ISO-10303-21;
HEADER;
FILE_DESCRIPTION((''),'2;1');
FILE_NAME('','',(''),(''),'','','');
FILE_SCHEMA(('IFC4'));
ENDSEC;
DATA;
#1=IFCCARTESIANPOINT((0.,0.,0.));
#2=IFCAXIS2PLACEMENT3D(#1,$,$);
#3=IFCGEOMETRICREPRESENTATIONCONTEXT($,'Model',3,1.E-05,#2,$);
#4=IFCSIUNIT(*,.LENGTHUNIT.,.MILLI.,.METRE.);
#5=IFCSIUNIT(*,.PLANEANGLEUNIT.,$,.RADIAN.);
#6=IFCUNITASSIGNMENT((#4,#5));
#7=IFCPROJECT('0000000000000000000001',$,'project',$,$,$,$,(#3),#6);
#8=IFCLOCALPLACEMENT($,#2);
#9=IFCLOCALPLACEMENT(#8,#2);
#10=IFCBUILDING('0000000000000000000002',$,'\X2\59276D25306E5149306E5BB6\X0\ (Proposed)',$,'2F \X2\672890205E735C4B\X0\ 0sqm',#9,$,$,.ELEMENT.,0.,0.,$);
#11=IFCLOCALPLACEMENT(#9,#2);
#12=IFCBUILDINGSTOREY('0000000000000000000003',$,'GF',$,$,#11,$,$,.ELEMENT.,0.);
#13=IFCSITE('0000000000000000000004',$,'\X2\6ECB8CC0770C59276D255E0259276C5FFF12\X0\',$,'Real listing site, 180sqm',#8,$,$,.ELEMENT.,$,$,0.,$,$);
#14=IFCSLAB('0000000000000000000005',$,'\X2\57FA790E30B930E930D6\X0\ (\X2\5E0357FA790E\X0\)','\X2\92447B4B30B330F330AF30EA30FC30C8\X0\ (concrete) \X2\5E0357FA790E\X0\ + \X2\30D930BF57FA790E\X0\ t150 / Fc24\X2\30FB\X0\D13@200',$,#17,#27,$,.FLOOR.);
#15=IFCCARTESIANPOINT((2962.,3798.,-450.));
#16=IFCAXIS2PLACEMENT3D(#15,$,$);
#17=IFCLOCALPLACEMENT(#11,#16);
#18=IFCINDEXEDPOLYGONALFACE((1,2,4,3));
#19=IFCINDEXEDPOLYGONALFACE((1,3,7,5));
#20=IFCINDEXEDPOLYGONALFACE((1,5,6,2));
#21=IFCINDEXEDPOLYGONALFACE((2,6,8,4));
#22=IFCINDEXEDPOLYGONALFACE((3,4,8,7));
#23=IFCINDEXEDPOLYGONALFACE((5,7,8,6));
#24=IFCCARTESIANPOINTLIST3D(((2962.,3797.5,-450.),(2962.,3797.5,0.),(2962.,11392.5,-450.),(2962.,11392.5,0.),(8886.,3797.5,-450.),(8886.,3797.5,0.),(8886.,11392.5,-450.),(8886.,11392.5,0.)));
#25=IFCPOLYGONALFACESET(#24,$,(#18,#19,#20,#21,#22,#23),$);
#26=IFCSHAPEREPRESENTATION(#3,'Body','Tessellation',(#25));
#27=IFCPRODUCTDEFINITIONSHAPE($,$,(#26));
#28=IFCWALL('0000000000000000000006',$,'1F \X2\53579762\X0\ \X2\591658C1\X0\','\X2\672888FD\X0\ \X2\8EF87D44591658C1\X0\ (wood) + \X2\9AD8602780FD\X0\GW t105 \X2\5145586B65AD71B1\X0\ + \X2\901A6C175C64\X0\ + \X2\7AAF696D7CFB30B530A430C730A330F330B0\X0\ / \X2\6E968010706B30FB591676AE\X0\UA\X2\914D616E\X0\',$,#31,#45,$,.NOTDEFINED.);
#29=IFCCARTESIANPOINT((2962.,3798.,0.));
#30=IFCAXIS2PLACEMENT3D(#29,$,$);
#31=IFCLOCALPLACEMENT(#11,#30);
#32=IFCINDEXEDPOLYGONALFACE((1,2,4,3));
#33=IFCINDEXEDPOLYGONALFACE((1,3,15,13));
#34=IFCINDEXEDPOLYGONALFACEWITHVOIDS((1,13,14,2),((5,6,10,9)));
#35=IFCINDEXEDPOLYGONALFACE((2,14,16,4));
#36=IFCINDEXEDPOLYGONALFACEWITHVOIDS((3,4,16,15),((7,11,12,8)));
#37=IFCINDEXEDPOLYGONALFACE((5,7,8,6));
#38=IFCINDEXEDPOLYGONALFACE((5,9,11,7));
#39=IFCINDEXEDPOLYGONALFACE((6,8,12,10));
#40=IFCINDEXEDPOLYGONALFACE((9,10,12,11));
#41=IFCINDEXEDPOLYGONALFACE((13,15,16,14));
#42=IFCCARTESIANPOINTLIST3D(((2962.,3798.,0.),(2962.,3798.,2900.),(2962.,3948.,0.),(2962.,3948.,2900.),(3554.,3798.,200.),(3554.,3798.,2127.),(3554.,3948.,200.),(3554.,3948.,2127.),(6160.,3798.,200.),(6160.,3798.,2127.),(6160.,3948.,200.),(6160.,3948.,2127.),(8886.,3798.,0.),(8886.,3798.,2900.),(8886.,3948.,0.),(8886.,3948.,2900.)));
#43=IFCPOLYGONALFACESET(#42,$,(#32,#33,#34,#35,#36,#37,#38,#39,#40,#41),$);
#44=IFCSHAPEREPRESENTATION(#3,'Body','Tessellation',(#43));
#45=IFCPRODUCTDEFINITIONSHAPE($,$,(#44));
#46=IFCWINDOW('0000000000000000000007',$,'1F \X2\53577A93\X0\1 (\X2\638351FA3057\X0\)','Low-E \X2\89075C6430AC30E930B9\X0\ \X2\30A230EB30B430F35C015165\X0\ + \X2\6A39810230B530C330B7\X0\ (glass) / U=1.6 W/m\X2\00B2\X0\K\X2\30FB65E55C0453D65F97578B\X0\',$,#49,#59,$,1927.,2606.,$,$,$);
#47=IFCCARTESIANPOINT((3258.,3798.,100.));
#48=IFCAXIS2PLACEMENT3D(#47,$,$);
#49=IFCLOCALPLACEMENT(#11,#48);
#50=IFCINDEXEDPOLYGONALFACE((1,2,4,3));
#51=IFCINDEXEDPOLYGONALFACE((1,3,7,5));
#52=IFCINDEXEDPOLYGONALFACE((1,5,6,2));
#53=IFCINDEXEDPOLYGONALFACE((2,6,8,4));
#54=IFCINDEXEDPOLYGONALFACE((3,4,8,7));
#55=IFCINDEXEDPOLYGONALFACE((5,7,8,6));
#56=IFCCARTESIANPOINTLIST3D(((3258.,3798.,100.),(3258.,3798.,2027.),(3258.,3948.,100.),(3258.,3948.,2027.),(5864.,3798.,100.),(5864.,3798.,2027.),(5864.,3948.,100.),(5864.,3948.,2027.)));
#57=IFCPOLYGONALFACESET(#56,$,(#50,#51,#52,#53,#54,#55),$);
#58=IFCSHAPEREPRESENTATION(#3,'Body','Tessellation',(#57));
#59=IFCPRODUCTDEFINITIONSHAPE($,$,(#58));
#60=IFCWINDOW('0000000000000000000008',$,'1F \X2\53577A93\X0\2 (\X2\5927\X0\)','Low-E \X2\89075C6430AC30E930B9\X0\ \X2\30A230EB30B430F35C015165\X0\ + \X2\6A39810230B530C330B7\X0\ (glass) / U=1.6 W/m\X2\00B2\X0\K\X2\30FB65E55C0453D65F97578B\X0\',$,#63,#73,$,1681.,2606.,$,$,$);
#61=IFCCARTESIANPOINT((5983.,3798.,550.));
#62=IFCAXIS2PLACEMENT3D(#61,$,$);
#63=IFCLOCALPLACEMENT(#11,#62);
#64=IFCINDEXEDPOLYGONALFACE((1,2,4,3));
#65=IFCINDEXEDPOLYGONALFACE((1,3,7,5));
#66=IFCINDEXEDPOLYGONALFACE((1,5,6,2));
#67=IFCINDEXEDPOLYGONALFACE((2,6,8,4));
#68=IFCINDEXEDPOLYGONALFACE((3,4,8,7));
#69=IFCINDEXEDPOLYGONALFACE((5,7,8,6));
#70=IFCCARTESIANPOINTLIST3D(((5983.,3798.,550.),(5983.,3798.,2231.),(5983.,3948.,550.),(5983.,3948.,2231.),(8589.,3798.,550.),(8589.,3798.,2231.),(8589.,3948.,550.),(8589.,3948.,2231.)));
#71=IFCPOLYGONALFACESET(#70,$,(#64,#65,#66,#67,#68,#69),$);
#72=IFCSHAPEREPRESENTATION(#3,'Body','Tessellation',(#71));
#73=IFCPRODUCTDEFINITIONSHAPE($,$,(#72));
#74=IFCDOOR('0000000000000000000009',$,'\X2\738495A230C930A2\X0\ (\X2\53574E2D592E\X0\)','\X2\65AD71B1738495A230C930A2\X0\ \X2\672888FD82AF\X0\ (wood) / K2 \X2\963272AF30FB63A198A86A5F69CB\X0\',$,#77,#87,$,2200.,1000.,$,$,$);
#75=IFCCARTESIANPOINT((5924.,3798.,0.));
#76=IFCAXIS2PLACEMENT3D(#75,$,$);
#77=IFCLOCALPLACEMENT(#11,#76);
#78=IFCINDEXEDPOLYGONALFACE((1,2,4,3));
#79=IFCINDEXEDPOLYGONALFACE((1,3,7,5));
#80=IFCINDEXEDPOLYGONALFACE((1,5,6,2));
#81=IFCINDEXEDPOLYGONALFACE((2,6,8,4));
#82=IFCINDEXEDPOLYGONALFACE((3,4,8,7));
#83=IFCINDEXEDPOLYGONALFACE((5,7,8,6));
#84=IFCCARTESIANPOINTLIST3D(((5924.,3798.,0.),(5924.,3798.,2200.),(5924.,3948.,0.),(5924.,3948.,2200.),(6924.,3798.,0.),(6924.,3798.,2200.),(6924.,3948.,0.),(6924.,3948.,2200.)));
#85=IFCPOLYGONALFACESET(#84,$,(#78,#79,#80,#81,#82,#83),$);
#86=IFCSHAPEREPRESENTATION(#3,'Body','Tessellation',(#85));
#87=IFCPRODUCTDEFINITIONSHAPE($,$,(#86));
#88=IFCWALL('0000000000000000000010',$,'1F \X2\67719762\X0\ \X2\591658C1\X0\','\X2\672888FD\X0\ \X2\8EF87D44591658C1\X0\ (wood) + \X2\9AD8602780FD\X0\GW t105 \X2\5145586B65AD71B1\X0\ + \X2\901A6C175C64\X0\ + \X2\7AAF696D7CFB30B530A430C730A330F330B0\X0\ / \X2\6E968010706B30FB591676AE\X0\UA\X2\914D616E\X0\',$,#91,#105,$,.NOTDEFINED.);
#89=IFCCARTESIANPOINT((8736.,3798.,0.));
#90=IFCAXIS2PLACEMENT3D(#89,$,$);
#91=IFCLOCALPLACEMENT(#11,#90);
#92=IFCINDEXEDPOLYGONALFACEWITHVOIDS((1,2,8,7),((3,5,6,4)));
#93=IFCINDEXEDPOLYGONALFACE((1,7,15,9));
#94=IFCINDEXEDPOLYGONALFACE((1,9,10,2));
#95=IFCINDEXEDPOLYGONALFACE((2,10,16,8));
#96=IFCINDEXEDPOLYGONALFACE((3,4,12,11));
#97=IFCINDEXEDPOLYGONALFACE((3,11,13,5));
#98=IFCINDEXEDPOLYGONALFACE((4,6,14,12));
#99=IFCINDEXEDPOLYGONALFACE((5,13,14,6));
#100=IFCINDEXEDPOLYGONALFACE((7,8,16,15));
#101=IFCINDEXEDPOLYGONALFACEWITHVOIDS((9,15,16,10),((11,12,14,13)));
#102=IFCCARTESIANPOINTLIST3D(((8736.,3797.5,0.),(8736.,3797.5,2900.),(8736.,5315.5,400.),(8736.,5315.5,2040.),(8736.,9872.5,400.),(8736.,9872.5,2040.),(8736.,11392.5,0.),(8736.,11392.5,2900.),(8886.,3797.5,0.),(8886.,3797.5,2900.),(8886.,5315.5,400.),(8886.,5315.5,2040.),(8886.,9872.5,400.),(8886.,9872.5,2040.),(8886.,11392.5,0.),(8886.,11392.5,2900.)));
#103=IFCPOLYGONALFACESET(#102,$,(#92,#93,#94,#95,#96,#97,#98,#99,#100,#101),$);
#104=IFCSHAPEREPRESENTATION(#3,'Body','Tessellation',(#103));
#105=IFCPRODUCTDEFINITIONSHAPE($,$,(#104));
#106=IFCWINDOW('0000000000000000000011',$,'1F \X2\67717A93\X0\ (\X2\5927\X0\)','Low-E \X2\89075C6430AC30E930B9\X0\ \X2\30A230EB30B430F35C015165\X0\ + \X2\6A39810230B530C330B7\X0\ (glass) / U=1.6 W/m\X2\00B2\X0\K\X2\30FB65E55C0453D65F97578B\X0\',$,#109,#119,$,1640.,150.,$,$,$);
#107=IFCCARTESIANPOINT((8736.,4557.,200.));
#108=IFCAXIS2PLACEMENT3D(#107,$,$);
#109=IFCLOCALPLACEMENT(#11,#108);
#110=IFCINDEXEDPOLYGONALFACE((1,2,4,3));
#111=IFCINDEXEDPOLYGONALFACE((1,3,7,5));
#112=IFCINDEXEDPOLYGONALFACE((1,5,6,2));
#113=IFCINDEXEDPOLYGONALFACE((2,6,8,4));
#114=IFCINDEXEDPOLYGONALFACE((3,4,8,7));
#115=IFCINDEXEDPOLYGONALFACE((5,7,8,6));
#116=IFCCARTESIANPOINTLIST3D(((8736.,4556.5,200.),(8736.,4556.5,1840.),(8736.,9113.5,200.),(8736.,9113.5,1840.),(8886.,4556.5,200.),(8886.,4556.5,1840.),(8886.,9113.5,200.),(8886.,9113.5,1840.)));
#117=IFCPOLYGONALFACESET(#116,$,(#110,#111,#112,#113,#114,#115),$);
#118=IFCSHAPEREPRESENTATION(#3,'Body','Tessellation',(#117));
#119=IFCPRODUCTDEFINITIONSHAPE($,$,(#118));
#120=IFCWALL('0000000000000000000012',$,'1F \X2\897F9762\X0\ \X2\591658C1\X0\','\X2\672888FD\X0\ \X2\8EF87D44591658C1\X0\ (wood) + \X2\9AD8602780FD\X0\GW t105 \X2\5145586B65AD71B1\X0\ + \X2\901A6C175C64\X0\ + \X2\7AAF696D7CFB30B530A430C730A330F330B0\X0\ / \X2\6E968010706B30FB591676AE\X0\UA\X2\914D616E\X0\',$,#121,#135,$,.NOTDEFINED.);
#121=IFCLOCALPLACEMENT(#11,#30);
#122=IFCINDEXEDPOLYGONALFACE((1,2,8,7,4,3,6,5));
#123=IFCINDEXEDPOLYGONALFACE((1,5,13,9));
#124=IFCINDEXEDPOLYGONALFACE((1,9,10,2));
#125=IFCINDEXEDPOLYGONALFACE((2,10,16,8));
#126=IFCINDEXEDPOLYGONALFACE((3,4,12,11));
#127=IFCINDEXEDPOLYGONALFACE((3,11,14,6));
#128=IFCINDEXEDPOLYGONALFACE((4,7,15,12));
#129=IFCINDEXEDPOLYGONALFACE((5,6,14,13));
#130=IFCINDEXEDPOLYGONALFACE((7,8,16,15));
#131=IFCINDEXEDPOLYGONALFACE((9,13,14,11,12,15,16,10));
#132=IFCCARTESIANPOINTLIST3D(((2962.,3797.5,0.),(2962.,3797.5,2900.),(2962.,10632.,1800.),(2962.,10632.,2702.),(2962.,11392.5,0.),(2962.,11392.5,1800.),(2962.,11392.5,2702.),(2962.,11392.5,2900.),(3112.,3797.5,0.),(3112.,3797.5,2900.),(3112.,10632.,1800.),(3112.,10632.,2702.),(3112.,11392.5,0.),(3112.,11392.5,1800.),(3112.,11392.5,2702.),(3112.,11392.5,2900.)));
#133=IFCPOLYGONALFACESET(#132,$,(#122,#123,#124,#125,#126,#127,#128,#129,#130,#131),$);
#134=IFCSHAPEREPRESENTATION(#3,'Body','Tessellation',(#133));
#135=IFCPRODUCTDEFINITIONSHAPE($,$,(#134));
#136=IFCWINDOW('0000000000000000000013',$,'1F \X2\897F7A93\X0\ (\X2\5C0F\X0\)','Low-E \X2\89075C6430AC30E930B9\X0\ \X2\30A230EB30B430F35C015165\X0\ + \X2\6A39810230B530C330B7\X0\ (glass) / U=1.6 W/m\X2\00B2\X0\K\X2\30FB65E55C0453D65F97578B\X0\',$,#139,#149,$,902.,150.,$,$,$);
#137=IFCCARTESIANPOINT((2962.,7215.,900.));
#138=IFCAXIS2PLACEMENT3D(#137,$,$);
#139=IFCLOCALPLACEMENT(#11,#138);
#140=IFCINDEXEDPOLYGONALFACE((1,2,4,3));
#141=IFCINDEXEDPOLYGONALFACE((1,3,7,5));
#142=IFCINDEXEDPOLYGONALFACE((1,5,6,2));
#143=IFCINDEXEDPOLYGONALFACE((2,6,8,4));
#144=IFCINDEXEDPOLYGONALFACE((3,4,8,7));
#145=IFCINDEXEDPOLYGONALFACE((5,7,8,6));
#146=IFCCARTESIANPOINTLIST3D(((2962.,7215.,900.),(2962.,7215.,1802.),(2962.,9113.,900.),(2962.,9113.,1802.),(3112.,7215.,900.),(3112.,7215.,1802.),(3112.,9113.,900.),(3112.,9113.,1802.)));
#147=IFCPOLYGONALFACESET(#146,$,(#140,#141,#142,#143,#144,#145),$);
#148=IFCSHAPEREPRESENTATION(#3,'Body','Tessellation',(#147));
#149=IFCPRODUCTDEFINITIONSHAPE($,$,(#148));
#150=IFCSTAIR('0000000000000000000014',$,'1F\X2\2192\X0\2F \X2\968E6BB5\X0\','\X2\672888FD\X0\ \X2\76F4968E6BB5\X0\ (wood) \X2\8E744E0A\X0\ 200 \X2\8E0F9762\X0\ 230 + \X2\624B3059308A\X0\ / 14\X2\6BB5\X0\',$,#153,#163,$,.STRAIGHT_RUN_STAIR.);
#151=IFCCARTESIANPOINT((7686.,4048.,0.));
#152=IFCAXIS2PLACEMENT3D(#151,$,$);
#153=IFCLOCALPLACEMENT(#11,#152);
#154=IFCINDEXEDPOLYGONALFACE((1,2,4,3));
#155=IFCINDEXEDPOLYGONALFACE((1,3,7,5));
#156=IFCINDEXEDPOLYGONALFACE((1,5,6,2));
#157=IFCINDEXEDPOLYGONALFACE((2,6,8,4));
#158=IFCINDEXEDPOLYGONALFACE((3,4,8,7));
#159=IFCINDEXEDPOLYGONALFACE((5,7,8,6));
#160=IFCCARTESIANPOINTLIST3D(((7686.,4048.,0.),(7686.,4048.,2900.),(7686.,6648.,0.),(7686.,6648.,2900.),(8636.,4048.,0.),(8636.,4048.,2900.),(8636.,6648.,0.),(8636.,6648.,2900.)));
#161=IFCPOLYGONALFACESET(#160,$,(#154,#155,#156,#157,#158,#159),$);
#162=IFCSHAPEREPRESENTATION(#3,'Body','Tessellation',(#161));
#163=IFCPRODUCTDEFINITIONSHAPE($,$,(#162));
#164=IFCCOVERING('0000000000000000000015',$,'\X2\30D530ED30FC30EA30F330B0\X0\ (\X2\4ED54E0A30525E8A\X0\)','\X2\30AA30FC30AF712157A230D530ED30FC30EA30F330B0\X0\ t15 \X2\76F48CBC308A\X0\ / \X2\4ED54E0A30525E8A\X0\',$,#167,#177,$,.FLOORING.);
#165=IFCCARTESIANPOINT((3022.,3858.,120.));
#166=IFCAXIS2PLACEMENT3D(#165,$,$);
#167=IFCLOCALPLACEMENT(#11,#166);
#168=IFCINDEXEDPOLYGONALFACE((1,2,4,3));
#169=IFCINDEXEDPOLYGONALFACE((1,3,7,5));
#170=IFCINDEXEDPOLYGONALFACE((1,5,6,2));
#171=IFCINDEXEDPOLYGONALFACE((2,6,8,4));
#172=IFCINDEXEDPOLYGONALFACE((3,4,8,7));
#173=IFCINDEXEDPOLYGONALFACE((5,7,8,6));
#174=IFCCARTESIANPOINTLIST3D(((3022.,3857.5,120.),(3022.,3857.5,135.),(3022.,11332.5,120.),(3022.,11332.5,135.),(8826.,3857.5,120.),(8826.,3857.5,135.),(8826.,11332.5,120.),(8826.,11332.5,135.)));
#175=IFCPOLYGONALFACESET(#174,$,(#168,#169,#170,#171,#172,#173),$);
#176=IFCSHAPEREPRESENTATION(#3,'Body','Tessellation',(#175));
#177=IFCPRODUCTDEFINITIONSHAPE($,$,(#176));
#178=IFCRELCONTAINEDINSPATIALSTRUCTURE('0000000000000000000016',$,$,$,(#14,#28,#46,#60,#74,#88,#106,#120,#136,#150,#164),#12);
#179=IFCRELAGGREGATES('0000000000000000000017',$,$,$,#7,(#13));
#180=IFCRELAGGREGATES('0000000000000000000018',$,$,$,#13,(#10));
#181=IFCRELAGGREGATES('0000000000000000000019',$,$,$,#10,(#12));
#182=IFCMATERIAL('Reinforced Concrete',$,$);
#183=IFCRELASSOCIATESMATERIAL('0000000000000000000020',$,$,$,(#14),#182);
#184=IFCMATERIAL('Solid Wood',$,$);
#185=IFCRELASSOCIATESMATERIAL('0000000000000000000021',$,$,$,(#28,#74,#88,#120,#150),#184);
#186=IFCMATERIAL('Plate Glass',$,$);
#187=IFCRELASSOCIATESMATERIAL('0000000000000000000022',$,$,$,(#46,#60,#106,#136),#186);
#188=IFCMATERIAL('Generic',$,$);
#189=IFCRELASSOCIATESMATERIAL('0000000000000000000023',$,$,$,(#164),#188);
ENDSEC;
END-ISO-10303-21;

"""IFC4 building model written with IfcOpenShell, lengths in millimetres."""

from ifc_helpers import new_model, si_unit, frame, frame_2d, origin, place, context, project, spatial, rectangle, extrude, material, element, fill, save


model = new_model("IFC4")

# Units and contexts
model_context = context("Model", 3, precision=1e-05, world=origin())
ifc_project = project(units=[si_unit("LENGTHUNIT", "METRE", prefix="MILLI"), si_unit("PLANEANGLEUNIT", "RADIAN")], contexts=[model_context])

# Site, building, storey
site_placement = place(None, origin())
site = spatial("IfcSite", under=ifc_project, at=site_placement, Name="滋賀県大津市大江２", ObjectType="Real listing site, 180sqm", CompositionType="ELEMENT", RefElevation=0.0)
building_placement = place(site_placement, origin())
building = spatial("IfcBuilding", under=site, at=building_placement, Name="大津の光の家 (Proposed)", ObjectType="2F 木造平屋 0sqm", CompositionType="ELEMENT", ElevationOfRefHeight=0.0, ElevationOfTerrain=0.0)
storey_placement = place(building_placement, origin())
storey = spatial("IfcBuildingStorey", under=building, at=storey_placement, Name="GF", CompositionType="ELEMENT", Elevation=0.0)

# Slab
ifc_material_1 = material(Name="Reinforced Concrete")
slab_1_placement = place(storey_placement, frame((2962.0, 3798.0, -450.0)))
element("IfcSlab", 1, at=slab_1_placement, inside=storey, material=ifc_material_1, Name="基礎スラブ (布基礎)", Description="鉄筋コンクリート (concrete) 布基礎 + ベタ基礎 t150 / Fc24・D13@200", PredefinedType="FLOOR", context=model_context, shape_type="SweptSolid", body=[
    extrude(rectangle(XDim=5924.0, YDim=7595.0, at=frame_2d((2962.0, 3797.0))), frame((2962.0, 3798.0, -450.0)), (0.0, 0.0, 1.0), 450.0),
])
ifc_material_2 = material(Name="Solid Wood")

# Wall, openings, windows, door
wall_1_placement = place(storey_placement, frame((2962.0, 3798.0, 0.0)))
wall_1 = element("IfcWall", 2, at=wall_1_placement, inside=storey, material=ifc_material_2, Name="1F 南面 外壁", Description="木製 軸組外壁 (wood) + 高性能GW t105 充填断熱 + 通気層 + 窯業系サイディング / 準耐火・外皮UA配慮", PredefinedType="NOTDEFINED", context=model_context, shape_type="SweptSolid", body=[
    extrude(rectangle(XDim=5924.0, YDim=150.0, at=frame_2d((2962.0, 75.0))), frame((2962.0, 3798.0, 0.0)), (0.0, 0.0, 1.0), 2900.0),
])
opening_1_placement = place(storey_placement, frame((3258.0, 3798.0, 100.0)))
opening_1 = element("IfcOpeningElement", 3, at=opening_1_placement, cuts=wall_1, PredefinedType="NOTDEFINED", context=model_context, shape_type="SweptSolid", body=[
    extrude(rectangle(XDim=2606.0, YDim=150.0, at=frame_2d((1303.0, 75.0))), frame((3258.0, 3798.0, 100.0)), (0.0, 0.0, 1.0), 1927.0),
])
opening_2_placement = place(storey_placement, frame((5983.0, 3798.0, 550.0)))
opening_2 = element("IfcOpeningElement", 4, at=opening_2_placement, cuts=wall_1, PredefinedType="NOTDEFINED", context=model_context, shape_type="SweptSolid", body=[
    extrude(rectangle(XDim=2606.0, YDim=150.0, at=frame_2d((1303.0, 75.0))), frame((5983.0, 3798.0, 550.0)), (0.0, 0.0, 1.0), 1681.0),
])
opening_3_placement = place(storey_placement, frame((5924.0, 3798.0, 0.0)))
opening_3 = element("IfcOpeningElement", 5, at=opening_3_placement, cuts=wall_1, PredefinedType="NOTDEFINED", context=model_context, shape_type="SweptSolid", body=[
    extrude(rectangle(XDim=1000.0, YDim=150.0, at=frame_2d((500.0, 75.0))), frame((5924.0, 3798.0, 0.0)), (0.0, 0.0, 1.0), 2200.0),
])
ifc_material_3 = material(Name="Plate Glass")
window_1_placement = place(storey_placement, frame((3258.0, 3798.0, 100.0)))
window_1 = element("IfcWindow", 6, at=window_1_placement, inside=storey, material=ifc_material_3, Name="1F 南窓1 (掃出し)", Description="Low-E 複層ガラス アルゴン封入 + 樹脂サッシ (glass) / U=1.6 W/m²K・日射取得型", OverallHeight=1927.0, OverallWidth=2606.0, context=model_context, shape_type="SweptSolid", body=[
    extrude(rectangle(XDim=2606.0, YDim=150.0, at=frame_2d((1303.0, 75.0))), frame((3258.0, 3798.0, 100.0)), (0.0, 0.0, 1.0), 1927.0),
])
fill(opening_1, window_1)
window_2_placement = place(storey_placement, frame((5983.0, 3798.0, 550.0)))
window_2 = element("IfcWindow", 7, at=window_2_placement, inside=storey, material=ifc_material_3, Name="1F 南窓2 (大)", Description="Low-E 複層ガラス アルゴン封入 + 樹脂サッシ (glass) / U=1.6 W/m²K・日射取得型", OverallHeight=1681.0, OverallWidth=2606.0, context=model_context, shape_type="SweptSolid", body=[
    extrude(rectangle(XDim=2606.0, YDim=150.0, at=frame_2d((1303.0, 75.0))), frame((5983.0, 3798.0, 550.0)), (0.0, 0.0, 1.0), 1681.0),
])
fill(opening_2, window_2)
door_placement = place(storey_placement, frame((5924.0, 3798.0, 0.0)))
door = element("IfcDoor", 8, at=door_placement, inside=storey, material=ifc_material_2, Name="玄関ドア (南中央)", Description="断熱玄関ドア 木製芯 (wood) / K2 防犯・採風機構", OverallHeight=2200.0, OverallWidth=1000.0, context=model_context, shape_type="SweptSolid", body=[
    extrude(rectangle(XDim=1000.0, YDim=150.0, at=frame_2d((500.0, 75.0))), frame((5924.0, 3798.0, 0.0)), (0.0, 0.0, 1.0), 2200.0),
])
fill(opening_3, door)

# Walls, openings, windows
wall_2_placement = place(storey_placement, frame((8736.0, 3798.0, 0.0)))
wall_2 = element("IfcWall", 9, at=wall_2_placement, inside=storey, material=ifc_material_2, Name="1F 東面 外壁", Description="木製 軸組外壁 (wood) + 高性能GW t105 充填断熱 + 通気層 + 窯業系サイディング / 準耐火・外皮UA配慮", PredefinedType="NOTDEFINED", context=model_context, shape_type="SweptSolid", body=[
    extrude(rectangle(XDim=150.0, YDim=7595.0, at=frame_2d((75.0, 3797.0))), frame((8736.0, 3798.0, 0.0)), (0.0, 0.0, 1.0), 2900.0),
])
opening_4_placement = place(storey_placement, frame((8736.0, 4557.0, 200.0)))
opening_4 = element("IfcOpeningElement", 10, at=opening_4_placement, cuts=wall_2, PredefinedType="NOTDEFINED", context=model_context, shape_type="SweptSolid", body=[
    extrude(rectangle(XDim=150.0, YDim=4557.0, at=frame_2d((75.0, 2278.0))), frame((8736.0, 4557.0, 200.0)), (0.0, 0.0, 1.0), 1640.0),
])
window_3_placement = place(storey_placement, frame((8736.0, 4557.0, 200.0)))
window_3 = element("IfcWindow", 11, at=window_3_placement, inside=storey, material=ifc_material_3, Name="1F 東窓 (大)", Description="Low-E 複層ガラス アルゴン封入 + 樹脂サッシ (glass) / U=1.6 W/m²K・日射取得型", OverallHeight=1640.0, OverallWidth=150.0, context=model_context, shape_type="SweptSolid", body=[
    extrude(rectangle(XDim=150.0, YDim=4557.0, at=frame_2d((75.0, 2278.0))), frame((8736.0, 4557.0, 200.0)), (0.0, 0.0, 1.0), 1640.0),
])
fill(opening_4, window_3)
wall_3_placement = place(storey_placement, frame((2962.0, 3798.0, 0.0)))
wall_3 = element("IfcWall", 12, at=wall_3_placement, inside=storey, material=ifc_material_2, Name="1F 西面 外壁", Description="木製 軸組外壁 (wood) + 高性能GW t105 充填断熱 + 通気層 + 窯業系サイディング / 準耐火・外皮UA配慮", PredefinedType="NOTDEFINED", context=model_context, shape_type="SweptSolid", body=[
    extrude(rectangle(XDim=150.0, YDim=7595.0, at=frame_2d((75.0, 3797.0))), frame((2962.0, 3798.0, 0.0)), (0.0, 0.0, 1.0), 2900.0),
])
opening_5_placement = place(storey_placement, frame((2962.0, 7215.0, 900.0)))
opening_5 = element("IfcOpeningElement", 13, at=opening_5_placement, cuts=wall_3, PredefinedType="NOTDEFINED", context=model_context, shape_type="SweptSolid", body=[
    extrude(rectangle(XDim=150.0, YDim=1898.0, at=frame_2d((75.0, 949.0))), frame((2962.0, 7215.0, 900.0)), (0.0, 0.0, 1.0), 902.0),
])
window_4_placement = place(storey_placement, frame((2962.0, 7215.0, 900.0)))
window_4 = element("IfcWindow", 14, at=window_4_placement, inside=storey, material=ifc_material_3, Name="1F 西窓 (小)", Description="Low-E 複層ガラス アルゴン封入 + 樹脂サッシ (glass) / U=1.6 W/m²K・日射取得型", OverallHeight=902.0, OverallWidth=150.0, context=model_context, shape_type="SweptSolid", body=[
    extrude(rectangle(XDim=150.0, YDim=1898.0, at=frame_2d((75.0, 949.0))), frame((2962.0, 7215.0, 900.0)), (0.0, 0.0, 1.0), 902.0),
])
fill(opening_5, window_4)

# Stair
stair_placement = place(storey_placement, frame((7686.0, 4048.0, 0.0)))
element("IfcStair", 15, at=stair_placement, inside=storey, material=ifc_material_2, Name="1F→2F 階段", Description="木製 直階段 (wood) 蹴上 200 踏面 230 + 手すり / 14段", PredefinedType="STRAIGHT_RUN_STAIR", context=model_context, shape_type="SweptSolid", body=[
    extrude(rectangle(XDim=950.0, YDim=2600.0, at=frame_2d((475.0, 1300.0))), frame((7686.0, 4048.0, 0.0)), (0.0, 0.0, 1.0), 2900.0),
])

# Covering
ifc_material_4 = material(Name="Generic")
covering_placement = place(storey_placement, frame((3022.0, 3858.0, 120.0)))
element("IfcCovering", 16, at=covering_placement, inside=storey, material=ifc_material_4, Name="フローリング (仕上げ床)", Description="オーク無垢フローリング t15 直貼り / 仕上げ床", PredefinedType="FLOORING", context=model_context, shape_type="SweptSolid", body=[
    extrude(rectangle(XDim=5804.0, YDim=7475.0, at=frame_2d((2902.0, 3737.0))), frame((3022.0, 3858.0, 120.0)), (0.0, 0.0, 1.0), 15.0),
])

save(model, "model.ifc")
